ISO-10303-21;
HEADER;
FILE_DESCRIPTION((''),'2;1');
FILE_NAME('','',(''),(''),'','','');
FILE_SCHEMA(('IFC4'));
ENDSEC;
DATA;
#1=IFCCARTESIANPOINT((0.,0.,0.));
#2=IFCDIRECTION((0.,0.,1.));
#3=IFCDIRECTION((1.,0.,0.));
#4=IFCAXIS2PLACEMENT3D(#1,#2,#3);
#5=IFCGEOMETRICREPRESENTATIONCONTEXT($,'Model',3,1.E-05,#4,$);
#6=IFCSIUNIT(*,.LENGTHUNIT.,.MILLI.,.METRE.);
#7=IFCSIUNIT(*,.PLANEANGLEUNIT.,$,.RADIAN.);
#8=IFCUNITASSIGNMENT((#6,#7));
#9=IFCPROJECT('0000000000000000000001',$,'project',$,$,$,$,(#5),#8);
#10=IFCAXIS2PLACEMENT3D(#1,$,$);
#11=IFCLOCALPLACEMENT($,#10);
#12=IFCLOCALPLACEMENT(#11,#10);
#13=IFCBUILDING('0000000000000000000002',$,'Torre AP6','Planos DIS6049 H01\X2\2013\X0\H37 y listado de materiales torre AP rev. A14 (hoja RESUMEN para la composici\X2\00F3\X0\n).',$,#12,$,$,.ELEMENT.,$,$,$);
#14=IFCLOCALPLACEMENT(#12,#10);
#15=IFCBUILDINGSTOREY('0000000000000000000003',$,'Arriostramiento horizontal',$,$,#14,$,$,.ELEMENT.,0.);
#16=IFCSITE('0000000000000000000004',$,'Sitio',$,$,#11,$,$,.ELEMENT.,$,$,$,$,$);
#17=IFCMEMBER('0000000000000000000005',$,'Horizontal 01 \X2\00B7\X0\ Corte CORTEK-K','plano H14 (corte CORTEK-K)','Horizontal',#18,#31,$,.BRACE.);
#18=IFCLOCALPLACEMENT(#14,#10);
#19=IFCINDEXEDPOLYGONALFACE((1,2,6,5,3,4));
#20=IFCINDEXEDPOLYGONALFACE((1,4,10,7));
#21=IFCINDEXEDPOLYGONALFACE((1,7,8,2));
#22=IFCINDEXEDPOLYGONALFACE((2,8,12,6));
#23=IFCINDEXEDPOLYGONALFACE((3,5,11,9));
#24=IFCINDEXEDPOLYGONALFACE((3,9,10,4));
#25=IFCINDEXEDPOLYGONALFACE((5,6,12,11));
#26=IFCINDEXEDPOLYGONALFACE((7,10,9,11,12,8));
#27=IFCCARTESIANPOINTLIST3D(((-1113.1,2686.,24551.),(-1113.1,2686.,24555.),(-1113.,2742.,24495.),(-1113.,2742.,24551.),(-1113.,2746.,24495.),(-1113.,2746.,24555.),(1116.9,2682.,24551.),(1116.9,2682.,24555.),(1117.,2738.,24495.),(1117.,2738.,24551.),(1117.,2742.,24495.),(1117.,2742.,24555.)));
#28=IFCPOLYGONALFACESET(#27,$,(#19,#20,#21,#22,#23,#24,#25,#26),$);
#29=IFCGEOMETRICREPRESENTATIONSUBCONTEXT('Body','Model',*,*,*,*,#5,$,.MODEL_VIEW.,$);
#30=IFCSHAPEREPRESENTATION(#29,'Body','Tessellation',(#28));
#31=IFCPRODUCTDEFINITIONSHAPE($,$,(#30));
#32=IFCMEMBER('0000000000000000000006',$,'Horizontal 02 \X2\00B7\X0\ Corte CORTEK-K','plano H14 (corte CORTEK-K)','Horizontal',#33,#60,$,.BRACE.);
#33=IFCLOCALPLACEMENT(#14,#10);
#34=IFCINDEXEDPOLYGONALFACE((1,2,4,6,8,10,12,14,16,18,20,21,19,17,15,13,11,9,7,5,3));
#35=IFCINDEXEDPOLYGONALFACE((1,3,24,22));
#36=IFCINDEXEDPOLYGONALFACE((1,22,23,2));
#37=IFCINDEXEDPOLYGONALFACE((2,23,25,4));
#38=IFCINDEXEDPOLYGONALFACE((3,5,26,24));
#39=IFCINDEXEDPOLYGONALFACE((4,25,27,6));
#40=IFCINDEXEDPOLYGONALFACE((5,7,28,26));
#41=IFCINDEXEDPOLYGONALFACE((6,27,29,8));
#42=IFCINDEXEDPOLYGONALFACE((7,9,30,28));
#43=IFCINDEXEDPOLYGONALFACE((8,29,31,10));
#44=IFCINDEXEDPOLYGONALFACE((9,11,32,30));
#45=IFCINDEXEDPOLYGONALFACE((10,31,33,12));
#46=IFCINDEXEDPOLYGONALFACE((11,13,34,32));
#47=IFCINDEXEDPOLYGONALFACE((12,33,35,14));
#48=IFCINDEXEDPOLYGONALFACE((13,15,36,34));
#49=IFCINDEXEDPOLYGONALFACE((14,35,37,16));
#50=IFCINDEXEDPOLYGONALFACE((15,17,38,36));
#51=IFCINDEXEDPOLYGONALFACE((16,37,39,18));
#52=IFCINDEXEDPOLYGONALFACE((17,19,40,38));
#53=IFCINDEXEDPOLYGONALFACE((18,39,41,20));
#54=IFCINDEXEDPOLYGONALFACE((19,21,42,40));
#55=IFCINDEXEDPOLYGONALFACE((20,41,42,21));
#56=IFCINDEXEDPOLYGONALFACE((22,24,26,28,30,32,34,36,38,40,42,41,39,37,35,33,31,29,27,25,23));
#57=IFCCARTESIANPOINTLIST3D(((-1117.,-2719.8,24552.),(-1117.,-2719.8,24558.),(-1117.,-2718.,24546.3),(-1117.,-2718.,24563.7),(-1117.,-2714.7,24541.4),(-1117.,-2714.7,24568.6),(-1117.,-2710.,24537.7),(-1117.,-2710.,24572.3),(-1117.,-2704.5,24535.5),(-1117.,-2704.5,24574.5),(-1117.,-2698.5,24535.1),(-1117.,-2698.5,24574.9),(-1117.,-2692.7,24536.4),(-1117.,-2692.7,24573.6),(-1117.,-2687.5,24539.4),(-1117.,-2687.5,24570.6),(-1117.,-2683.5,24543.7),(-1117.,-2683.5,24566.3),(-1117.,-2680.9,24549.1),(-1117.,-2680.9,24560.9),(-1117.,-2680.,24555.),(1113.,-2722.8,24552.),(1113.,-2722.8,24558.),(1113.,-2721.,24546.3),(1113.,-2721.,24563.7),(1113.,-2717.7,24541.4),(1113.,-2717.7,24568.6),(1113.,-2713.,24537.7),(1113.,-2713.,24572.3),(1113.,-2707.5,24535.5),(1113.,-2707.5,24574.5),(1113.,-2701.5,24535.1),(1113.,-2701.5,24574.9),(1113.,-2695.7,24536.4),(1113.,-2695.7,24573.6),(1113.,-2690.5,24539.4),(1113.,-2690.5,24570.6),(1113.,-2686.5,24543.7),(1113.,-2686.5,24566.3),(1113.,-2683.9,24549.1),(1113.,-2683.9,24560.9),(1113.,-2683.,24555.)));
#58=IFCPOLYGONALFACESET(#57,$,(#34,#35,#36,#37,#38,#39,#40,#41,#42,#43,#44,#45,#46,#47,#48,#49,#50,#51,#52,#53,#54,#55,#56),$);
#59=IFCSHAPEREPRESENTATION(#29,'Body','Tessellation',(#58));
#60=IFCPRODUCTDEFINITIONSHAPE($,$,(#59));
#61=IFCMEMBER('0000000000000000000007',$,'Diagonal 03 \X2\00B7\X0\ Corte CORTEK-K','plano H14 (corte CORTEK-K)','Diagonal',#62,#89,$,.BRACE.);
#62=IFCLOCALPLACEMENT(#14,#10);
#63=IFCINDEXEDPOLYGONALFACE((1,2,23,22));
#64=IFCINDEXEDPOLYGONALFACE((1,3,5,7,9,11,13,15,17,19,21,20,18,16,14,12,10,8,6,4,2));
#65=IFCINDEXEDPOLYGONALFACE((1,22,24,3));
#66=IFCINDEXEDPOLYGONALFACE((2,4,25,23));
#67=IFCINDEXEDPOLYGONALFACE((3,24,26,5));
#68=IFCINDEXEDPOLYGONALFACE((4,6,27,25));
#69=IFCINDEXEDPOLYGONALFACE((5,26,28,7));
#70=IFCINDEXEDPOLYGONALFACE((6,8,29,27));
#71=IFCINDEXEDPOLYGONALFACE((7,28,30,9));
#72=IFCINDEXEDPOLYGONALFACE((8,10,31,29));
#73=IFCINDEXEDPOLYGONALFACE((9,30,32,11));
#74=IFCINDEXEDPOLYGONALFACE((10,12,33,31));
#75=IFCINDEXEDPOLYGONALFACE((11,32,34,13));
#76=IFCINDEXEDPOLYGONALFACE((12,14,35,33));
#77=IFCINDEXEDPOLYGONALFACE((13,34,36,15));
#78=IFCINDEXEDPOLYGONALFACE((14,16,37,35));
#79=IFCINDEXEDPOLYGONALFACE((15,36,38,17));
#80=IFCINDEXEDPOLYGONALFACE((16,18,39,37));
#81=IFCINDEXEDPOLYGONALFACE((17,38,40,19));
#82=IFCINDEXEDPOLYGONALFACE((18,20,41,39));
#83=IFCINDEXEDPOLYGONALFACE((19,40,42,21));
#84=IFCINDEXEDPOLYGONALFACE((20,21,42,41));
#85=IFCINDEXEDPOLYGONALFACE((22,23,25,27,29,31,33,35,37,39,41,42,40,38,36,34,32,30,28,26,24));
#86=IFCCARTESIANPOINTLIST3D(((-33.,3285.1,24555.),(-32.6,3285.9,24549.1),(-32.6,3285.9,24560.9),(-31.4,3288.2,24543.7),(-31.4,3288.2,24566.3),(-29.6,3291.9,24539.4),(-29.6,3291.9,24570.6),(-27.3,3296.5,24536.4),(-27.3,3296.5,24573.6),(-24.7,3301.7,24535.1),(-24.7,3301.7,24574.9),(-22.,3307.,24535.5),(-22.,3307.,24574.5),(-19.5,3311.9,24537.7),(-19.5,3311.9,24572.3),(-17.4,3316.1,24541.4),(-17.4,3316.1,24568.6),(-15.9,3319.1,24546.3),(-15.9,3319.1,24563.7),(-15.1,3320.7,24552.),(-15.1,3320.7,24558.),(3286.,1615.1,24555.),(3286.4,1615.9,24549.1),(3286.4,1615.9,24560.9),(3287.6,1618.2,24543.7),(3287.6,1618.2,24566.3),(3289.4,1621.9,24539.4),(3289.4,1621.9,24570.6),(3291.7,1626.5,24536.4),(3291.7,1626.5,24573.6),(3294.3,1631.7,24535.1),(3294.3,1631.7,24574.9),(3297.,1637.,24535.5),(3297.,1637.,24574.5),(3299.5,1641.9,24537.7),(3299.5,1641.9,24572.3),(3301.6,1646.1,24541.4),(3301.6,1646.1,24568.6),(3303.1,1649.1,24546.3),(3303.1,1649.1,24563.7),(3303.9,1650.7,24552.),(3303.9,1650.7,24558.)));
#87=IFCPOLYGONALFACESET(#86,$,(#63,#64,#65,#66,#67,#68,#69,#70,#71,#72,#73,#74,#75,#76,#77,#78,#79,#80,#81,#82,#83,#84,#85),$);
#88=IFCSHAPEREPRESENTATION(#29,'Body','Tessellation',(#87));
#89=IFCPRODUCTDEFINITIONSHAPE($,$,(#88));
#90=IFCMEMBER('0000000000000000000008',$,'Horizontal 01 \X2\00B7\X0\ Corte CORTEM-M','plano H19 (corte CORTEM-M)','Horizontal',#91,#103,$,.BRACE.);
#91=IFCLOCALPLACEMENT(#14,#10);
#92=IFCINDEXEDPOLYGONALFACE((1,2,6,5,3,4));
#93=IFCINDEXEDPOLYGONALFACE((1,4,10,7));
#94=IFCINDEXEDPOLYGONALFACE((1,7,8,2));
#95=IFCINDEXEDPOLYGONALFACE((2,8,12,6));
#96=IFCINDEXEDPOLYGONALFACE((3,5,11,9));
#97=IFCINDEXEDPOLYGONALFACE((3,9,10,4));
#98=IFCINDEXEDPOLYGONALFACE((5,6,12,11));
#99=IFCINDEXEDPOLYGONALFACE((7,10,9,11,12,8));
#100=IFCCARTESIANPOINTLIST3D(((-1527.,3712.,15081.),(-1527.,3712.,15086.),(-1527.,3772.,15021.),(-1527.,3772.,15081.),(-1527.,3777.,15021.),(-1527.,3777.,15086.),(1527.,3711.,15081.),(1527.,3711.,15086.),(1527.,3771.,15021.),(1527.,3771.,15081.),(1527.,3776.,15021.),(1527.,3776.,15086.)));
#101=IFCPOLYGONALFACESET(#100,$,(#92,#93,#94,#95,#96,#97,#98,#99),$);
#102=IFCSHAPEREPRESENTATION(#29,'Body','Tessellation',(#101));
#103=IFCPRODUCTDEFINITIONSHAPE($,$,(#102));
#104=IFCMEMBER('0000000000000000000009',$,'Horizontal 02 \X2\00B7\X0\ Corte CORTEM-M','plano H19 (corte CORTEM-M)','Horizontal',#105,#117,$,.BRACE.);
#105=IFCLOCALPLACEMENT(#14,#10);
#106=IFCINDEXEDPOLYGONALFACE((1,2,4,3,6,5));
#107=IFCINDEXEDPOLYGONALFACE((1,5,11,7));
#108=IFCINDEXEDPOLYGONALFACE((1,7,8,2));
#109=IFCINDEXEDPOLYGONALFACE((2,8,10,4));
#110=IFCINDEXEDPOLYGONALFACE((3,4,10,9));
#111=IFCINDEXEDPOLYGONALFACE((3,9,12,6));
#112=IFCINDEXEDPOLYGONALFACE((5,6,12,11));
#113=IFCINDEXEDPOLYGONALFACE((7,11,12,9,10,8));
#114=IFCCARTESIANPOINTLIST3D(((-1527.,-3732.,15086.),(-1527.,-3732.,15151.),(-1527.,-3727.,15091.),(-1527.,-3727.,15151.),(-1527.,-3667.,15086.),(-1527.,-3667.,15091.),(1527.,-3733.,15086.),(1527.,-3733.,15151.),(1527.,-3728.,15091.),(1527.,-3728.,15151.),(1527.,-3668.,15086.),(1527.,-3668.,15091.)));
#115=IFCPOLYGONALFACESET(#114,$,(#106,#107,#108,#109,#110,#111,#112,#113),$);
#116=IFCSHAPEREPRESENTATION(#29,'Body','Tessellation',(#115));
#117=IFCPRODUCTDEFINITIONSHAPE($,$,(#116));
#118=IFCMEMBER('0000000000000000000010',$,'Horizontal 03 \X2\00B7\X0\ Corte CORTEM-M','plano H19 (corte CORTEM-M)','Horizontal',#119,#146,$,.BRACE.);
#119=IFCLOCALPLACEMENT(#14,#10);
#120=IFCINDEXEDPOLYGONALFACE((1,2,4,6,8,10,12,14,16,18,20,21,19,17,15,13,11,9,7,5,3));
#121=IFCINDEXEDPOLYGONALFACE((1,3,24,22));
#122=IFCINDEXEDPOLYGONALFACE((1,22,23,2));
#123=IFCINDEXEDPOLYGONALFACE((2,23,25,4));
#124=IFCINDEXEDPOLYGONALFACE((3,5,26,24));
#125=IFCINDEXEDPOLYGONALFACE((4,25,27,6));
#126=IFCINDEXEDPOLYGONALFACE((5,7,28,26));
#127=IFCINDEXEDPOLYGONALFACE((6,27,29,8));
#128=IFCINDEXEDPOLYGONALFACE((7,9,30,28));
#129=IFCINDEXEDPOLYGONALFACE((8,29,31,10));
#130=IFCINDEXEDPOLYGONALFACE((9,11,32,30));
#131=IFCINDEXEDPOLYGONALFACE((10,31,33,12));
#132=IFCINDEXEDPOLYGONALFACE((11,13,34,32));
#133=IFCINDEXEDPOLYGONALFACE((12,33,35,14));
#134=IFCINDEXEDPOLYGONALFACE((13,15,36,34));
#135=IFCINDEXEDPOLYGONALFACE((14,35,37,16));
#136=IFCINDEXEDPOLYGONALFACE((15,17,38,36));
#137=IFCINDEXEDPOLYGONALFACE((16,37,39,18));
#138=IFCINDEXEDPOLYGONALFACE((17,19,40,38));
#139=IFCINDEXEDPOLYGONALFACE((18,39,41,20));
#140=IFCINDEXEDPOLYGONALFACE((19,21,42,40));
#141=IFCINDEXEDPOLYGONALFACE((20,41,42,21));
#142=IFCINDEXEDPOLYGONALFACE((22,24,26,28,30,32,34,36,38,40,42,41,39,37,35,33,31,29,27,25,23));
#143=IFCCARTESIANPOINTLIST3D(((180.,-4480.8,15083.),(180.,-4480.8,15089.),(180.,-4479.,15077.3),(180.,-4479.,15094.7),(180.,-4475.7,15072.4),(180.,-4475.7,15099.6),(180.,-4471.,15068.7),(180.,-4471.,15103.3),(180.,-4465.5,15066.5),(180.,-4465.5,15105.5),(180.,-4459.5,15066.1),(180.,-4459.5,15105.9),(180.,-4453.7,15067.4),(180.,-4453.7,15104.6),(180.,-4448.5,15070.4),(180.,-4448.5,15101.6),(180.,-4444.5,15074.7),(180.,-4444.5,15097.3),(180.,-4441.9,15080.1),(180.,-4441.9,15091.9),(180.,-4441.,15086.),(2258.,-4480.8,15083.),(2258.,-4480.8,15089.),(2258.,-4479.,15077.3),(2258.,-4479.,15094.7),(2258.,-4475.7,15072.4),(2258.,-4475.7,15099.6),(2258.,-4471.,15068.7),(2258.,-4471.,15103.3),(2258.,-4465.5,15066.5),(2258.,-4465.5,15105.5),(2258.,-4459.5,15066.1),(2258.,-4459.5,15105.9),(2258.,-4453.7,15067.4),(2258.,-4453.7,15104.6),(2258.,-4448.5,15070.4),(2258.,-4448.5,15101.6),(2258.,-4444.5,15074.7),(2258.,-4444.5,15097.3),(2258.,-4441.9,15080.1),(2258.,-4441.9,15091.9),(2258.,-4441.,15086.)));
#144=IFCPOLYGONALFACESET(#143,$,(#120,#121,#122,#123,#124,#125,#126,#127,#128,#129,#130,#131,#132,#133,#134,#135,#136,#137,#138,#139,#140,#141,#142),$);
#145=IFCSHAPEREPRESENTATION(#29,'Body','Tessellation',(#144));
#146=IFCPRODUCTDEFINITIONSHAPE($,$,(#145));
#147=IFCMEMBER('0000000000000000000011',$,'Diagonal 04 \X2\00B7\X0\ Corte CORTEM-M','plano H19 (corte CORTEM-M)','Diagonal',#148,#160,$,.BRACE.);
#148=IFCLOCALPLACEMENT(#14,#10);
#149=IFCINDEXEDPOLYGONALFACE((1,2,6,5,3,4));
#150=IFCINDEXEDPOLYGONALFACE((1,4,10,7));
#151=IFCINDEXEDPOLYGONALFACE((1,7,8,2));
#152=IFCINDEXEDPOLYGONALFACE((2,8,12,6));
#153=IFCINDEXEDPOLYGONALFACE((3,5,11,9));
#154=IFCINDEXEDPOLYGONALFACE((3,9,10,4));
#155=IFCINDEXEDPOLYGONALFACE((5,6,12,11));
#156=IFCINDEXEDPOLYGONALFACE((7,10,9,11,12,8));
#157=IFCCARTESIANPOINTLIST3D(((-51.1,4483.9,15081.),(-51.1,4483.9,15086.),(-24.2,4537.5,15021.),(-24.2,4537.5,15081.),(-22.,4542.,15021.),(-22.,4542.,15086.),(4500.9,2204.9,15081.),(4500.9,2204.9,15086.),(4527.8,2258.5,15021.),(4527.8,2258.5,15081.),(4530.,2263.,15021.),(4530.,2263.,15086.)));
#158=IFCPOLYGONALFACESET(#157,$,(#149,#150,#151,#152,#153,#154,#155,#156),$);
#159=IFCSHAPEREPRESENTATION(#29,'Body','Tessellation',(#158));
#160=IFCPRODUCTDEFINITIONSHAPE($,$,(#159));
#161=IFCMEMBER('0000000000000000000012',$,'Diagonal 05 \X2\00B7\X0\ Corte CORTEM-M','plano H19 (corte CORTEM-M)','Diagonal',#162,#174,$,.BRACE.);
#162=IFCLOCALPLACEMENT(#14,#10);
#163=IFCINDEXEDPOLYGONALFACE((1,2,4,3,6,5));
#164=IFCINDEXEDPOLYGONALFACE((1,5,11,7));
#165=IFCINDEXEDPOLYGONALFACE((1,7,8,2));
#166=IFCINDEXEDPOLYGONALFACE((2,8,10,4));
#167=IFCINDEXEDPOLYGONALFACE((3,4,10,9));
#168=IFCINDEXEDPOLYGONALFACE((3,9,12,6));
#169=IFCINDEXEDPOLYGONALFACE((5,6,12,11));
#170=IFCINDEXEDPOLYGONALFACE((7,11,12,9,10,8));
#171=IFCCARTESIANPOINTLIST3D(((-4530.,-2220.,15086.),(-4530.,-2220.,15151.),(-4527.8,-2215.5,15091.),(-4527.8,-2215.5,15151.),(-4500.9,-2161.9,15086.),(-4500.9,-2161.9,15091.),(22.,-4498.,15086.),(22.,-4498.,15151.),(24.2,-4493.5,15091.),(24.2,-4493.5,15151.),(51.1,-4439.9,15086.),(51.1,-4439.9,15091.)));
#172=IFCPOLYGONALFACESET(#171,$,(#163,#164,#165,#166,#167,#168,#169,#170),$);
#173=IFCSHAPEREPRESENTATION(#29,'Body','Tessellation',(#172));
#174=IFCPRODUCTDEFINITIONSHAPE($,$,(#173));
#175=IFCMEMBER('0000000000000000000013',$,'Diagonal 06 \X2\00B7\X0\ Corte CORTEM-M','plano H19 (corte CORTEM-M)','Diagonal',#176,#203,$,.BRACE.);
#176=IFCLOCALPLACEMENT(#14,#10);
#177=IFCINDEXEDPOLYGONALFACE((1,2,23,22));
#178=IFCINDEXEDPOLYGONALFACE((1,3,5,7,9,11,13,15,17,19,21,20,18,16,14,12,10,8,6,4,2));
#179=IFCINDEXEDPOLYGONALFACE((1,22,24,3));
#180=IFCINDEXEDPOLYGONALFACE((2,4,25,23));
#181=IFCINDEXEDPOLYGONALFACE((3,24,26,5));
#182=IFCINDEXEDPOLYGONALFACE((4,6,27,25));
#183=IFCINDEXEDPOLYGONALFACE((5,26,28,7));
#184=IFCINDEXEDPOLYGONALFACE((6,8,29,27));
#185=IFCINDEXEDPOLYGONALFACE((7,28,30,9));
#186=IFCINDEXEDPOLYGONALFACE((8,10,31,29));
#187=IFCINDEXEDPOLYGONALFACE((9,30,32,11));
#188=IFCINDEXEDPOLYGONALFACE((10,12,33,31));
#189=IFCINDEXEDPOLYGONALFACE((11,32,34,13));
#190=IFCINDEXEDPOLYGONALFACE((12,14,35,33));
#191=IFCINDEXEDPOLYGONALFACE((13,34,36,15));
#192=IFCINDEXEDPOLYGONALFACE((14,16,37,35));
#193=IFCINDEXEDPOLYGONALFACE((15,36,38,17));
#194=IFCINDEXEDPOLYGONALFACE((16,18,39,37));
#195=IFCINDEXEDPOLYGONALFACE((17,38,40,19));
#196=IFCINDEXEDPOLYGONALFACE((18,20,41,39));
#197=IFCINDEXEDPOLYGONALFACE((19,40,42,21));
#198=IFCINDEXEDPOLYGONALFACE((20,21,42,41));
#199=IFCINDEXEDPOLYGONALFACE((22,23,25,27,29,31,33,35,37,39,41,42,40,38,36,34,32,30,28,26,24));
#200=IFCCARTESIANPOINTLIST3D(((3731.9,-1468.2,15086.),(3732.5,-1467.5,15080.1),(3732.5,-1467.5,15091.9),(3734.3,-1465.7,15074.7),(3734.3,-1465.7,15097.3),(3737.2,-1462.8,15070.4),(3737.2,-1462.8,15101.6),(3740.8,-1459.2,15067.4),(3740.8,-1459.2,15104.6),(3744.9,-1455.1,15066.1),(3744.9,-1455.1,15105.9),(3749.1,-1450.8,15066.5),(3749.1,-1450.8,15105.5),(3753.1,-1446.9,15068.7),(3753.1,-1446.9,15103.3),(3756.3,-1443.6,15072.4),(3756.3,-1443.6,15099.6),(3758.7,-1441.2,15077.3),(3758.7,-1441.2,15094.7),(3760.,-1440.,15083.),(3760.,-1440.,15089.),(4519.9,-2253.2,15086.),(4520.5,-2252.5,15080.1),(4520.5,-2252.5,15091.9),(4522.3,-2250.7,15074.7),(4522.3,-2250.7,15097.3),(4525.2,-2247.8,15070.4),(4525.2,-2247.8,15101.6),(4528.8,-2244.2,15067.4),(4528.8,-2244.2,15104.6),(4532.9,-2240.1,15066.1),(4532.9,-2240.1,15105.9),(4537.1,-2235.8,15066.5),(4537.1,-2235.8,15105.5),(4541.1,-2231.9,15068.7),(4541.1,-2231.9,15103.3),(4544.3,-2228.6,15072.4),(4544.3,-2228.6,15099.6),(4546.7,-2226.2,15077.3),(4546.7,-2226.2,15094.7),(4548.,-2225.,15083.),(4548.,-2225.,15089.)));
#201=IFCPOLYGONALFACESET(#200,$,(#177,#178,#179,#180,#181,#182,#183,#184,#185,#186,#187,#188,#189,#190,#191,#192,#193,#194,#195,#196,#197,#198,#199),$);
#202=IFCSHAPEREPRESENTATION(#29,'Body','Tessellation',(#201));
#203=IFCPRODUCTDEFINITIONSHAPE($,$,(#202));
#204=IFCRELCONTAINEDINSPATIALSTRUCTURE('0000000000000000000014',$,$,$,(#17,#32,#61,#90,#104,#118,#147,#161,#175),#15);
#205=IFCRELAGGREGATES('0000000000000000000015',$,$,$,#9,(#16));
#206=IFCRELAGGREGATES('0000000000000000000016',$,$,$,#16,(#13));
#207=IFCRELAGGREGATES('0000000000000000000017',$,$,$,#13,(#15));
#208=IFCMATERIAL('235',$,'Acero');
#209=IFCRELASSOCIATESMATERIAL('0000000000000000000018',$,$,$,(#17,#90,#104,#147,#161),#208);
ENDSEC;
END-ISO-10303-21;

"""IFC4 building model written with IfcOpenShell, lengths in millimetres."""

from ifc_helpers import new_model, si_unit, frame, frame_2d, origin, origin_with_axes, place, context, subcontext, project, spatial, circle, l_section, extrude, material, element, save


model = new_model("IFC4")

# Units and contexts
model_context = context("Model", 3, precision=1e-05, world=origin_with_axes())
body_context = subcontext(model_context, "Body", "Model", "MODEL_VIEW")
ifc_project = project(units=[si_unit("LENGTHUNIT", "METRE", prefix="MILLI"), si_unit("PLANEANGLEUNIT", "RADIAN")], contexts=[model_context])

# Site, building, storey
site_placement = place(None, origin())
site = spatial("IfcSite", under=ifc_project, at=site_placement, Name="Sitio", CompositionType="ELEMENT")
building_placement = place(site_placement, origin())
building = spatial("IfcBuilding", under=site, at=building_placement, Name="Torre AP6", Description="Planos DIS6049 H01–H37 y listado de materiales torre AP rev. A14 (hoja RESUMEN para la composición).", CompositionType="ELEMENT")
storey_placement = place(building_placement, origin())
storey = spatial("IfcBuildingStorey", under=building, at=storey_placement, Name="Arriostramiento horizontal", CompositionType="ELEMENT", Elevation=0.0)

# Members
ifc_material = material(Name="235", Category="Acero")
member_1_placement = place(storey_placement, frame((-1113.0, 2746.0, 24555.0), z_axis=(0.999998, -0.001794, 0.0), x_axis=(-0.001794, -0.999998, 0.0)))
element("IfcMember", 1, at=member_1_placement, inside=storey, material=ifc_material, Name="Horizontal 01 · Corte CORTEK-K", Description="plano H14 (corte CORTEK-K)", ObjectType="Horizontal", PredefinedType="BRACE", context=body_context, shape_type="SweptSolid", body=[
    extrude(l_section(Depth=60.0, Width=60.0, Thickness=4.0, at=frame_2d((30.0, 30.0))), None, (0.0, 0.0, 1.0), 2230.0),
])
member_2_placement = place(storey_placement, frame((-1117.0, -2700.0, 24555.0), z_axis=(0.999999, -0.001345, 0.0), x_axis=(0.001345, 0.999999, 0.0)))
element("IfcMember", 2, at=member_2_placement, inside=storey, Name="Horizontal 02 · Corte CORTEK-K", Description="plano H14 (corte CORTEK-K)", ObjectType="Horizontal", PredefinedType="BRACE", context=body_context, shape_type="SweptSolid", body=[
    extrude(circle(Radius=20.0), None, (0.0, 0.0, 1.0), 2230.0),
])
member_3_placement = place(storey_placement, frame((-24.0, 3303.0, 24555.0), z_axis=(0.893294, -0.449473, 0.0), x_axis=(-0.449473, -0.893294, 0.0)))
element("IfcMember", 3, at=member_3_placement, inside=storey, Name="Diagonal 03 · Corte CORTEK-K", Description="plano H14 (corte CORTEK-K)", ObjectType="Diagonal", PredefinedType="BRACE", context=body_context, shape_type="SweptSolid", body=[
    extrude(circle(Radius=20.0), None, (0.0, 0.0, 1.0), 3715.5),
])
for number, where, z_axis, x_axis, name in (
    (4, (-1527.0, 3777.0, 15086.0), (1.0, -0.000327, 0.0), (-0.000327, -1.0, 0.0), "Horizontal 01 · Corte CORTEM-M"),
    (5, (-1527.0, -3732.0, 15086.0), (1.0, -0.000327, 0.0), (0.000327, 1.0, 0.0), "Horizontal 02 · Corte CORTEM-M"),
):
    element("IfcMember", number, at=place(storey_placement, frame(where, z_axis=z_axis, x_axis=x_axis)), inside=storey, material=ifc_material, Name=name, Description="plano H19 (corte CORTEM-M)", ObjectType="Horizontal", PredefinedType="BRACE", context=body_context, shape_type="SweptSolid", body=[
        extrude(l_section(Depth=65.0, Width=65.0, Thickness=5.0, at=frame_2d((32.5, 32.5))), None, (0.0, 0.0, 1.0), 3054.0),
    ])
member_4_placement = place(storey_placement, frame((180.0, -4461.0, 15086.0), z_axis=(1.0, 0.0, 0.0), x_axis=(0.0, 1.0, 0.0)))
element("IfcMember", 6, at=member_4_placement, inside=storey, Name="Horizontal 03 · Corte CORTEM-M", Description="plano H19 (corte CORTEM-M)", ObjectType="Horizontal", PredefinedType="BRACE", context=body_context, shape_type="SweptSolid", body=[
    extrude(circle(Radius=20.0), None, (0.0, 0.0, 1.0), 2078.0),
])
member_5_placement = place(storey_placement, frame((-22.0, 4542.0, 15086.0), z_axis=(0.894191, -0.447685, 0.0), x_axis=(-0.447685, -0.894191, 0.0)))
element("IfcMember", 7, at=member_5_placement, inside=storey, material=ifc_material, Name="Diagonal 04 · Corte CORTEM-M", Description="plano H19 (corte CORTEM-M)", ObjectType="Diagonal", PredefinedType="BRACE", context=body_context, shape_type="SweptSolid", body=[
    extrude(l_section(Depth=65.0, Width=65.0, Thickness=5.0, at=frame_2d((32.5, 32.5))), None, (0.0, 0.0, 1.0), 5090.6),
])
member_6_placement = place(storey_placement, frame((-4530.0, -2220.0, 15086.0), z_axis=(0.89427, -0.447528, 0.0), x_axis=(0.447528, 0.89427, 0.0)))
element("IfcMember", 8, at=member_6_placement, inside=storey, material=ifc_material, Name="Diagonal 05 · Corte CORTEM-M", Description="plano H19 (corte CORTEM-M)", ObjectType="Diagonal", PredefinedType="BRACE", context=body_context, shape_type="SweptSolid", body=[
    extrude(l_section(Depth=65.0, Width=65.0, Thickness=5.0, at=frame_2d((32.5, 32.5))), None, (0.0, 0.0, 1.0), 5090.2),
])
member_7_placement = place(storey_placement, frame((3746.0, -1454.0, 15086.0), z_axis=(0.708454, -0.705757, 0.0), x_axis=(-0.705757, -0.708454, 0.0)))
element("IfcMember", 9, at=member_7_placement, inside=storey, Name="Diagonal 06 · Corte CORTEM-M", Description="plano H19 (corte CORTEM-M)", ObjectType="Diagonal", PredefinedType="BRACE", context=body_context, shape_type="SweptSolid", body=[
    extrude(circle(Radius=20.0), None, (0.0, 0.0, 1.0), 1112.3),
])

save(model, "model.ifc")
